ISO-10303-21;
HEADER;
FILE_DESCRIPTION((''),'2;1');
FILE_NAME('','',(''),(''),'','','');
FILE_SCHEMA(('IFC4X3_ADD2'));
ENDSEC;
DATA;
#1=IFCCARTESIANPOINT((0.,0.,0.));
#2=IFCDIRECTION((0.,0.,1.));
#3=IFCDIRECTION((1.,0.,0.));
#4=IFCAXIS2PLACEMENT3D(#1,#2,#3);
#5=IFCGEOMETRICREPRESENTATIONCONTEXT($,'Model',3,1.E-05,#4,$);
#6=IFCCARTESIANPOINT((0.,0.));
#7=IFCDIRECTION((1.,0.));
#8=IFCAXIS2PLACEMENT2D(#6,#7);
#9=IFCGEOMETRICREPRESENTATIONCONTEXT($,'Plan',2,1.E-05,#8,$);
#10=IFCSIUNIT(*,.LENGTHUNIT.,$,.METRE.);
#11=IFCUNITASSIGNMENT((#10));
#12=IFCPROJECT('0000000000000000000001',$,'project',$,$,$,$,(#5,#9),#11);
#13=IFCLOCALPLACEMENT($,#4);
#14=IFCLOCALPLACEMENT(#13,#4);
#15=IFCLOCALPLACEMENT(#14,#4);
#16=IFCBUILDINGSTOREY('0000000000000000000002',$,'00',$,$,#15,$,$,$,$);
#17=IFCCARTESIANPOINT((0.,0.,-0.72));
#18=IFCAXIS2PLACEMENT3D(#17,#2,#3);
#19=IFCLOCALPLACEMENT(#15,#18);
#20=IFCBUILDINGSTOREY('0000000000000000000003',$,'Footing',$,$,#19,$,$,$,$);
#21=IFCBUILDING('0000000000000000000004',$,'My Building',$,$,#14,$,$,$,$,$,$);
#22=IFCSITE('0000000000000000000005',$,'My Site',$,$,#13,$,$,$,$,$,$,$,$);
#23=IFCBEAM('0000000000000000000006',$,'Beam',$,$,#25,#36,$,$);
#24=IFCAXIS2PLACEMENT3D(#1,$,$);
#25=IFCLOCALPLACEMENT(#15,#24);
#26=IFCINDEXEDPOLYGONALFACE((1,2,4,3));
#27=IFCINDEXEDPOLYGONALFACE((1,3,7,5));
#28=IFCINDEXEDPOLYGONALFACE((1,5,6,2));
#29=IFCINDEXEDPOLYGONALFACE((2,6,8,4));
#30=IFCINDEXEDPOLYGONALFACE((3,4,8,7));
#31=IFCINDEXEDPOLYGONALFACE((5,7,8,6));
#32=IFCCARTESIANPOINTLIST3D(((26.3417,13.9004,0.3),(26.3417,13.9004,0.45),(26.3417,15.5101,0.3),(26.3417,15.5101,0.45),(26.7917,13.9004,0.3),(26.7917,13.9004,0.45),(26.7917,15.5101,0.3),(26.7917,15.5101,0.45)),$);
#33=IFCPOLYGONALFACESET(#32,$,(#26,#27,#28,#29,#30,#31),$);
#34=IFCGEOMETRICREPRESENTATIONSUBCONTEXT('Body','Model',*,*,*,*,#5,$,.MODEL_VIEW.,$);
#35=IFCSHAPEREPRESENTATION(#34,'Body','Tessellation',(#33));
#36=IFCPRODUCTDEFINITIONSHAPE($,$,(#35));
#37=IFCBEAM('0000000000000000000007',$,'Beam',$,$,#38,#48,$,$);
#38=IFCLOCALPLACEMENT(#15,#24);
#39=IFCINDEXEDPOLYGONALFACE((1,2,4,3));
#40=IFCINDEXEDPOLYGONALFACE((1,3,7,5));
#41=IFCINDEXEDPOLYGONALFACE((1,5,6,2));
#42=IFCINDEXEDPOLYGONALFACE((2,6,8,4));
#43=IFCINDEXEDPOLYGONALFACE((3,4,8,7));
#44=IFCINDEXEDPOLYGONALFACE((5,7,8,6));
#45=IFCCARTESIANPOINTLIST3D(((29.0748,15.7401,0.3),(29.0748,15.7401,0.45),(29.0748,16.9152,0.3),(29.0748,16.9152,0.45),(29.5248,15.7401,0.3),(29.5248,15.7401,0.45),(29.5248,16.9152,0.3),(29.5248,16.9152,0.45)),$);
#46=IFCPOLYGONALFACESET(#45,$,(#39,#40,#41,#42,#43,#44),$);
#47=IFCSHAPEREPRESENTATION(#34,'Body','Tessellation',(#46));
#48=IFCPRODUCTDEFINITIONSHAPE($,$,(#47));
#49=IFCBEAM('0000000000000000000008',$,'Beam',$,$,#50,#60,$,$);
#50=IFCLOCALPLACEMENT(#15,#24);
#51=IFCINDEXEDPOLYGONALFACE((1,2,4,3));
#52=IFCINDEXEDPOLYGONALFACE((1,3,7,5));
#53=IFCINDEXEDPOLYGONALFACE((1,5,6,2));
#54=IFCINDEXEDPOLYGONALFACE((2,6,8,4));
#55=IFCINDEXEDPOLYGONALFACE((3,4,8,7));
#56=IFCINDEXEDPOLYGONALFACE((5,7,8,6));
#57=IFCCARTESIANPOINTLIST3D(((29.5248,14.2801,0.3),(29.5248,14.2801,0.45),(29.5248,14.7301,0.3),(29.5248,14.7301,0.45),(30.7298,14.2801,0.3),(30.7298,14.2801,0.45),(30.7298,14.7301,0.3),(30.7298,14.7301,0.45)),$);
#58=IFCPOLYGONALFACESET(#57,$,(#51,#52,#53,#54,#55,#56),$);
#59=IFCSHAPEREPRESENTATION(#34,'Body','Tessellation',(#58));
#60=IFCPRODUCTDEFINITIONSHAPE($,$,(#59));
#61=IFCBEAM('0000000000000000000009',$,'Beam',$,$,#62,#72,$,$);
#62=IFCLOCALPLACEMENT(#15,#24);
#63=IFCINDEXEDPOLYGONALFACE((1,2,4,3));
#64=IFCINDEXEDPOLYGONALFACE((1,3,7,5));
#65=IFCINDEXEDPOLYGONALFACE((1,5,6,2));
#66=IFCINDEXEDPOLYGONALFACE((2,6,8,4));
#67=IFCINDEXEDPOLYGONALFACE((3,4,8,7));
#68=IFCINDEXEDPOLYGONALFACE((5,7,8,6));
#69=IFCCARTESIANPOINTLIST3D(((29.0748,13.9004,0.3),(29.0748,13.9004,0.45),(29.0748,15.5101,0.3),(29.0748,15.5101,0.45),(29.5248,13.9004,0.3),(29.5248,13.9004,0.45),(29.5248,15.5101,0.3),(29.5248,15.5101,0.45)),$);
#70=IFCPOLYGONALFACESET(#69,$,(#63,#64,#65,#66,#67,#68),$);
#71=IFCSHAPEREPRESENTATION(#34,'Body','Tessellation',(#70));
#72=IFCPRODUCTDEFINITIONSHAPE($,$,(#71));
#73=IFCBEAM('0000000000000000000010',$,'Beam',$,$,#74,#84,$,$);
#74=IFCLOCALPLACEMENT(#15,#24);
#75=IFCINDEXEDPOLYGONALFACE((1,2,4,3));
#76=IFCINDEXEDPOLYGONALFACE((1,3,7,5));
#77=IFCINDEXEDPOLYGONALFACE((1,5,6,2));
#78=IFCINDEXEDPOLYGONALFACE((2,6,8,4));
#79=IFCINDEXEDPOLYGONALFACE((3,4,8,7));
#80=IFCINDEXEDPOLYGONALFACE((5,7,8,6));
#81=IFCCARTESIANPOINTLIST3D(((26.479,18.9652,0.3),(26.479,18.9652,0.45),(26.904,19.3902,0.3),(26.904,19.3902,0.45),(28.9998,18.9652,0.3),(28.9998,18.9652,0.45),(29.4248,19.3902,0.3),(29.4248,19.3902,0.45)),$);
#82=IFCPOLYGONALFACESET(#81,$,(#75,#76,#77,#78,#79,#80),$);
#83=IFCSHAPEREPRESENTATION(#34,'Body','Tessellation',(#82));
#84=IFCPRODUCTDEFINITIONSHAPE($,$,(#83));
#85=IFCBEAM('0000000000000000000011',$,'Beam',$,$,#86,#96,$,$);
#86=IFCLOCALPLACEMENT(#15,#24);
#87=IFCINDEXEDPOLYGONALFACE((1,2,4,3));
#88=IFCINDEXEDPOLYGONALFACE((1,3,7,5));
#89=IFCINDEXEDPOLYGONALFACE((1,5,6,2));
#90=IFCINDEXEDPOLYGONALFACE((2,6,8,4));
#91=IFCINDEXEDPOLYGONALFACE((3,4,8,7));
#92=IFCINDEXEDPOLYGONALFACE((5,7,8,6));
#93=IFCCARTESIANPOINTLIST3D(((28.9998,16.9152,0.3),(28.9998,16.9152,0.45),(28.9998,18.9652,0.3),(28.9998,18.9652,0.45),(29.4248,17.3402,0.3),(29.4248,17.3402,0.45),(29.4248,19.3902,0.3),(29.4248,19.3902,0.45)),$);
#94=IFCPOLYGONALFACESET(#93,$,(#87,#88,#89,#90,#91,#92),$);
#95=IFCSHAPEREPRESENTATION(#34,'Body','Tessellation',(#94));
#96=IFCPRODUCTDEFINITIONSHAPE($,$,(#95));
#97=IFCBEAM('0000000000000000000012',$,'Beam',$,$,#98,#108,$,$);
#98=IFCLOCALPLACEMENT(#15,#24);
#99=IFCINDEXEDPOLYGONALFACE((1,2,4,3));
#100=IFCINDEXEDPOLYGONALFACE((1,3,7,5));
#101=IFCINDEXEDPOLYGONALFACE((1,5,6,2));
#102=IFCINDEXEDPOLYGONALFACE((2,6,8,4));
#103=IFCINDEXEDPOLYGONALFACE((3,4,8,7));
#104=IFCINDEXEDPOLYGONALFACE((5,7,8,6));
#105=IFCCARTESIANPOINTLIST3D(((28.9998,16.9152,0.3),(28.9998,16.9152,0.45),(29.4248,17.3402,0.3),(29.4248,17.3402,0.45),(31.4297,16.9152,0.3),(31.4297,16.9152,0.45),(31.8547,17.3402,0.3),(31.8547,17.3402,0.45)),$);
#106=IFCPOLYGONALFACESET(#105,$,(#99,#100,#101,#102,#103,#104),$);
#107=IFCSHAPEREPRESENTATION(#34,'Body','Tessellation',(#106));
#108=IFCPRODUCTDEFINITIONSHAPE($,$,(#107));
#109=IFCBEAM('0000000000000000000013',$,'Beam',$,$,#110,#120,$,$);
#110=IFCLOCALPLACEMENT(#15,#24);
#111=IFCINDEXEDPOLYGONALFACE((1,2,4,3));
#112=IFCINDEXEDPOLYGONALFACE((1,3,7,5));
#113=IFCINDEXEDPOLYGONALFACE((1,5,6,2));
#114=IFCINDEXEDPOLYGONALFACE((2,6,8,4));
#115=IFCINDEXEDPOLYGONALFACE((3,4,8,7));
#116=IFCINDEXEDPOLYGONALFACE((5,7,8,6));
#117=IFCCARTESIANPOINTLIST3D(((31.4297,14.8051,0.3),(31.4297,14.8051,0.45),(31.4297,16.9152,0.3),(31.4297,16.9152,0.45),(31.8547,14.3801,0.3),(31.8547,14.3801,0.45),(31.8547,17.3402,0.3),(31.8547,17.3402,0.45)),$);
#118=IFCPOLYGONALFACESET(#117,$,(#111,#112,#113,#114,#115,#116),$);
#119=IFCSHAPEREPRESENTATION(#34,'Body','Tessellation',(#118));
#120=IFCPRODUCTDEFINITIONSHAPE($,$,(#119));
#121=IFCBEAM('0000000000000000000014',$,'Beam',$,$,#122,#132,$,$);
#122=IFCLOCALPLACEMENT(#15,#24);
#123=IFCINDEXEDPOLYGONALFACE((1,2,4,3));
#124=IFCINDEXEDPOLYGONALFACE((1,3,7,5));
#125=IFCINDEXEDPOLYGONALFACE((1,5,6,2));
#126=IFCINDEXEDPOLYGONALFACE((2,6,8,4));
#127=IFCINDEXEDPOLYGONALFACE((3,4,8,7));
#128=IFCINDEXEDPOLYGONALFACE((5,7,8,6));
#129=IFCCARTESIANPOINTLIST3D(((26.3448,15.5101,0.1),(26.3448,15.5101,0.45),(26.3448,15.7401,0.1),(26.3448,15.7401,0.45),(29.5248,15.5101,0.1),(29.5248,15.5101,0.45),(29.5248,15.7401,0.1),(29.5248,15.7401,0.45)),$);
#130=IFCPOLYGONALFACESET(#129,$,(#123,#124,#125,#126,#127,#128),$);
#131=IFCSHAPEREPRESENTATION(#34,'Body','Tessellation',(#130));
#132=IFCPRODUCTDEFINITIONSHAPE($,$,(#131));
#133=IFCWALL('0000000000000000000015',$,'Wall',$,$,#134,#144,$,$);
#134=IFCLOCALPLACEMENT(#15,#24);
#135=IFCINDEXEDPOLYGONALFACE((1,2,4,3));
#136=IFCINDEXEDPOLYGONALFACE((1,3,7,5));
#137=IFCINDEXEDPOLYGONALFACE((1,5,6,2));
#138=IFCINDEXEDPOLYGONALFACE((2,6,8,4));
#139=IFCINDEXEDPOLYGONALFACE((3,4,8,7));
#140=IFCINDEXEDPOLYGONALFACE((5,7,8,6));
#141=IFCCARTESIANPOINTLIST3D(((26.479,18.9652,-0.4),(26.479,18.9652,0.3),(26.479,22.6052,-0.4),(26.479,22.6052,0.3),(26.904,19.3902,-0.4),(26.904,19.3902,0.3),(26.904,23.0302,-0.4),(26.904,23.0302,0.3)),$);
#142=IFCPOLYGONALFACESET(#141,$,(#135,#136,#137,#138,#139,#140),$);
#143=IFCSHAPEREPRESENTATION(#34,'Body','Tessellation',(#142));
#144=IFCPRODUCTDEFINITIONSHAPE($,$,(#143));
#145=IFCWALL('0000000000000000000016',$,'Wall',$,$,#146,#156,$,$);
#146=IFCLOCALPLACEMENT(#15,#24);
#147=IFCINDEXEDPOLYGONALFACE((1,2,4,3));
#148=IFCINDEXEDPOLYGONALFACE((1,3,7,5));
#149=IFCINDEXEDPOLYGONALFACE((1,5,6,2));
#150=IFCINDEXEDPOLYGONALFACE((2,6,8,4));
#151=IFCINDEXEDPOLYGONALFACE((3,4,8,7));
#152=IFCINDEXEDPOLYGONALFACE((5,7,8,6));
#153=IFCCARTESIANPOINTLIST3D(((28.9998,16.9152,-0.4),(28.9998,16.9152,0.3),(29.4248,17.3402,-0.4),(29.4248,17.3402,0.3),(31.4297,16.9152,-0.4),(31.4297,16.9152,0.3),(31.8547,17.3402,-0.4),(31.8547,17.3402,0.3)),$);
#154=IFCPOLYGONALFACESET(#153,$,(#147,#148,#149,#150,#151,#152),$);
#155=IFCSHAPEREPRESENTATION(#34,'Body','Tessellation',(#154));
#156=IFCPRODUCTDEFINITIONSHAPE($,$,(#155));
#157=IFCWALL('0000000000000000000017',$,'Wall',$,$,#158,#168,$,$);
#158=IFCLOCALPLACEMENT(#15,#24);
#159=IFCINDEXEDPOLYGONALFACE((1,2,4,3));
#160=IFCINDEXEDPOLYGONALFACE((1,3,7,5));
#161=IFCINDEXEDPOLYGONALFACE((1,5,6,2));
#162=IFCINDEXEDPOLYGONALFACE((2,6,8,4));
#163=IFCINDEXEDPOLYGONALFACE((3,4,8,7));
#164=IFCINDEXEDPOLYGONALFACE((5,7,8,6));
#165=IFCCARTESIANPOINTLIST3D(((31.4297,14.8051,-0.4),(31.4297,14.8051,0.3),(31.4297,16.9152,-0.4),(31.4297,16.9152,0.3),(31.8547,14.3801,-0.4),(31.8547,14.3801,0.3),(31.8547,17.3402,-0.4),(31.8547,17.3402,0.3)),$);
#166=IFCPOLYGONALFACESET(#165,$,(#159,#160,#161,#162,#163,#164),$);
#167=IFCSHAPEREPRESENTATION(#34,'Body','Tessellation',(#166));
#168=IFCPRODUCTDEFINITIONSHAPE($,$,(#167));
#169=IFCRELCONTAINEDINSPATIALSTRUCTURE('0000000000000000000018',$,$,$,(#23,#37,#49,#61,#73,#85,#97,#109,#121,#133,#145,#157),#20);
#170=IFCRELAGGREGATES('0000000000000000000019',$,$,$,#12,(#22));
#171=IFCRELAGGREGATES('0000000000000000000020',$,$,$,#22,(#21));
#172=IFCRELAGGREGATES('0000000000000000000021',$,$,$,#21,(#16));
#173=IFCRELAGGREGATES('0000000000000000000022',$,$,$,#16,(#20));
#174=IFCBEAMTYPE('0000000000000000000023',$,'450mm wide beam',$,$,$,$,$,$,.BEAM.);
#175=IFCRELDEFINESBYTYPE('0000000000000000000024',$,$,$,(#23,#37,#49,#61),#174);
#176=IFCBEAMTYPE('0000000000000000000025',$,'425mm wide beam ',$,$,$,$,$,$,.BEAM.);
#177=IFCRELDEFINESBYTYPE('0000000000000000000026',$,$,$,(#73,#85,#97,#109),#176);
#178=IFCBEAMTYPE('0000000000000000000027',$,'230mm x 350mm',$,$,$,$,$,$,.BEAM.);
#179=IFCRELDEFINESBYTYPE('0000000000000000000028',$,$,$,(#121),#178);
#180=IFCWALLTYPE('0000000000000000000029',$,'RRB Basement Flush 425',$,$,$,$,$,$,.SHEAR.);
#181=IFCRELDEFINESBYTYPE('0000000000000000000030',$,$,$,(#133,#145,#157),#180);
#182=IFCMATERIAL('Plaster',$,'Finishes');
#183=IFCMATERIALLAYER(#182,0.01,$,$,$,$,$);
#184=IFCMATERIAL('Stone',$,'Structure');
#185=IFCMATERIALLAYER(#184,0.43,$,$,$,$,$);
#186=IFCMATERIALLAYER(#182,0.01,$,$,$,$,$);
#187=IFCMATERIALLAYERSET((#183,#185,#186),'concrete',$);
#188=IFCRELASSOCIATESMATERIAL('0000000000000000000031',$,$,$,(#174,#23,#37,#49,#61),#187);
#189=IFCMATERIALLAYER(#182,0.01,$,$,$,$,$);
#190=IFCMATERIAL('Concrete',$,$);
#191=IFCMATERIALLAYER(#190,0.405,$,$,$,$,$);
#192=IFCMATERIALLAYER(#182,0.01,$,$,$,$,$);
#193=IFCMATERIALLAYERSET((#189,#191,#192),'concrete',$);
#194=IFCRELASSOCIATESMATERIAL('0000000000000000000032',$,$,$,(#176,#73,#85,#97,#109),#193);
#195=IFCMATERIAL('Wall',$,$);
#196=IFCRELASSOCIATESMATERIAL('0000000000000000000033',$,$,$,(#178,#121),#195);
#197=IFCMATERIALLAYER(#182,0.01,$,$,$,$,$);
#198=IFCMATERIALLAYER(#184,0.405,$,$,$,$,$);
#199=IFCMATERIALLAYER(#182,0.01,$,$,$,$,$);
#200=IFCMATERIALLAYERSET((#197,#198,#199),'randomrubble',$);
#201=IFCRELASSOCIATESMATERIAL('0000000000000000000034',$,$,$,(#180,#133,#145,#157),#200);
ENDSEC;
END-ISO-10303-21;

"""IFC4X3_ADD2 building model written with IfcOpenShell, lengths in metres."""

from ifc_helpers import new_model, si_unit, frame, origin_with_axes, origin_2d_with_axis, place, context, subcontext, project, spatial, line, indexed_curve, rectangle, outline, extrude, material, layer, layer_set, layer_usage, material_profile, profile_set, profile_usage, type_object, element, save


model = new_model("IFC4X3_ADD2")

# Units and contexts
model_context = context("Model", 3, precision=1e-05, world=origin_with_axes())
plan_context = context("Plan", 2, precision=1e-05, world=origin_2d_with_axis())
body_context = subcontext(model_context, "Body", "Model", "MODEL_VIEW")
ifc_project = project(units=[si_unit("LENGTHUNIT", "METRE")], contexts=[model_context, plan_context])

# Site, building, storeys
site_placement = place(None, origin_with_axes())
site = spatial("IfcSite", under=ifc_project, at=site_placement, Name="My Site")
building_placement = place(site_placement, origin_with_axes())
building = spatial("IfcBuilding", under=site, at=building_placement, Name="My Building")
storey_1_placement = place(building_placement, origin_with_axes())
storey_1 = spatial("IfcBuildingStorey", under=building, at=storey_1_placement, Name="00")
storey_2_placement = place(storey_1_placement, frame((0.0, 0.0, -0.72), z_axis=(0.0, 0.0, 1.0), x_axis=(1.0, 0.0, 0.0)))
storey_2 = spatial("IfcBuildingStorey", under=storey_1, at=storey_2_placement, Name="Footing")

# Beams
ifc_material_1 = material(Name="Plaster", Category="Finishes")
ifc_layer_1 = layer(ifc_material_1, 0.01)
ifc_material_2 = material(Name="Stone", Category="Structure")
ifc_layer_2 = layer(ifc_material_2, 0.43)
ifc_layer_3 = layer(ifc_material_1, 0.01)
ifc_layer_set_1 = layer_set([ifc_layer_1, ifc_layer_2, ifc_layer_3], Name="concrete")
ifc_layer_usage_1 = layer_usage(ifc_layer_set_1, "AXIS2", "NEGATIVE", 0.0)
beam_type_1 = type_object("IfcBeamType", Name="450mm wide beam", PredefinedType="BEAM", material=ifc_layer_set_1)
beam_1_placement = place(storey_2_placement, frame((26.7917, 15.5101, 1.02), z_axis=(0.0, 0.0, 1.0), x_axis=(0.0, -1.0, 0.0)))
element("IfcBeam", 1, at=beam_1_placement, inside=storey_2, type_object=beam_type_1, material=ifc_layer_usage_1, Name="Beam", context=body_context, shape_type="SweptSolid", body=[
    extrude(outline(indexed_curve([(0.0, -0.45), (0.0, 0.0), (1.6097, 0.0), (1.6097, -0.45)], segments=[line(1, 2, 3, 4, 1)])), origin_with_axes(), (0.0, 0.0, 1.0), 0.15),
])
ifc_layer_usage_2 = layer_usage(ifc_layer_set_1, "AXIS2", "NEGATIVE", 0.0)
beam_2_placement = place(storey_2_placement, frame((29.5248, 16.9152, 1.02), z_axis=(0.0, 0.0, 1.0), x_axis=(0.0, -1.0, 0.0)))
element("IfcBeam", 2, at=beam_2_placement, inside=storey_2, type_object=beam_type_1, material=ifc_layer_usage_2, Name="Beam", context=body_context, shape_type="SweptSolid", body=[
    extrude(outline(indexed_curve([(0.0, -0.45), (0.0, 0.0), (1.175, 0.0), (1.175, -0.45)], segments=[line(1, 2, 3, 4, 1)])), origin_with_axes(), (0.0, 0.0, 1.0), 0.15),
])
ifc_layer_usage_3 = layer_usage(ifc_layer_set_1, "AXIS2", "NEGATIVE", 0.0)
beam_3_placement = place(storey_2_placement, frame((29.5248, 14.7301, 1.02), z_axis=(0.0, 0.0, 1.0), x_axis=(1.0, 0.0, 0.0)))
element("IfcBeam", 3, at=beam_3_placement, inside=storey_2, type_object=beam_type_1, material=ifc_layer_usage_3, Name="Beam", context=body_context, shape_type="SweptSolid", body=[
    extrude(outline(indexed_curve([(0.0, -0.45), (0.0, 0.0), (1.205, 0.0), (1.205, -0.45)], segments=[line(1, 2, 3, 4, 1)])), origin_with_axes(), (0.0, 0.0, 1.0), 0.15),
])
ifc_layer_usage_4 = layer_usage(ifc_layer_set_1, "AXIS2", "NEGATIVE", 0.0)
beam_4_placement = place(storey_2_placement, frame((29.5248, 15.5101, 1.02), z_axis=(0.0, 0.0, 1.0), x_axis=(0.0, -1.0, 0.0)))
element("IfcBeam", 4, at=beam_4_placement, inside=storey_2, type_object=beam_type_1, material=ifc_layer_usage_4, Name="Beam", context=body_context, shape_type="SweptSolid", body=[
    extrude(outline(indexed_curve([(0.0, -0.45), (0.0, 0.0), (1.6097, 0.0), (1.6097, -0.45)], segments=[line(1, 2, 3, 4, 1)])), origin_with_axes(), (0.0, 0.0, 1.0), 0.15),
])
ifc_layer_4 = layer(ifc_material_1, 0.01)
ifc_material_3 = material(Name="Concrete")
ifc_layer_5 = layer(ifc_material_3, 0.405)
ifc_layer_6 = layer(ifc_material_1, 0.01)
ifc_layer_set_2 = layer_set([ifc_layer_4, ifc_layer_5, ifc_layer_6], Name="concrete")
ifc_layer_usage_5 = layer_usage(ifc_layer_set_2, "AXIS2", "POSITIVE", 0.0)
beam_type_2 = type_object("IfcBeamType", Name="425mm wide beam ", PredefinedType="BEAM", material=ifc_layer_set_2)
beam_5_placement = place(storey_2_placement, frame((26.479, 18.9652, 1.02), z_axis=(0.0, 0.0, 1.0), x_axis=(1.0, 0.0, 0.0)))
element("IfcBeam", 5, at=beam_5_placement, inside=storey_2, type_object=beam_type_2, material=ifc_layer_usage_5, Name="Beam", context=body_context, shape_type="SweptSolid", body=[
    extrude(outline(indexed_curve([(0.0, 0.0), (0.425, 0.425), (2.9458, 0.425), (2.5208, 0.0)], segments=[line(1, 2, 3, 4, 1)])), origin_with_axes(), (0.0, 0.0, 1.0), 0.15),
])
ifc_layer_usage_6 = layer_usage(ifc_layer_set_2, "AXIS2", "POSITIVE", 0.0)
beam_6_placement = place(storey_2_placement, frame((28.9998, 18.9652, 1.02), z_axis=(0.0, 0.0, 1.0), x_axis=(0.0, -1.0, 0.0)))
element("IfcBeam", 6, at=beam_6_placement, inside=storey_2, type_object=beam_type_2, material=ifc_layer_usage_6, Name="Beam", context=body_context, shape_type="SweptSolid", body=[
    extrude(outline(indexed_curve([(0.0, 0.0), (-0.425, 0.425), (1.625, 0.425), (2.05, 0.0)], segments=[line(1, 2, 3, 4, 1)])), origin_with_axes(), (0.0, 0.0, 1.0), 0.15),
])
ifc_layer_usage_7 = layer_usage(ifc_layer_set_2, "AXIS2", "POSITIVE", 0.0)
beam_7_placement = place(storey_2_placement, frame((28.9998, 16.9152, 1.02), z_axis=(0.0, 0.0, 1.0), x_axis=(1.0, 0.0, 0.0)))
element("IfcBeam", 7, at=beam_7_placement, inside=storey_2, type_object=beam_type_2, material=ifc_layer_usage_7, Name="Beam", context=body_context, shape_type="SweptSolid", body=[
    extrude(outline(indexed_curve([(0.0, 0.0), (0.425, 0.425), (2.855, 0.425), (2.43, 0.0)], segments=[line(1, 2, 3, 4, 1)])), origin_with_axes(), (0.0, 0.0, 1.0), 0.15),
])
ifc_layer_usage_8 = layer_usage(ifc_layer_set_2, "AXIS2", "POSITIVE", 0.0)
beam_8_placement = place(storey_2_placement, frame((31.4297, 16.9152, 1.02), z_axis=(0.0, 0.0, 1.0), x_axis=(0.0, -1.0, 0.0)))
element("IfcBeam", 8, at=beam_8_placement, inside=storey_2, type_object=beam_type_2, material=ifc_layer_usage_8, Name="Beam", context=body_context, shape_type="SweptSolid", body=[
    extrude(outline(indexed_curve([(0.0, 0.0), (-0.425, 0.425), (2.535, 0.425), (2.11, 0.0)], segments=[line(1, 2, 3, 4, 1)])), origin_with_axes(), (0.0, 0.0, 1.0), 0.15),
])
ifc_material_4 = material(Name="Wall")
ifc_material_profile_1 = material_profile(ifc_material_4, rectangle(XDim=0.23, YDim=0.35))
ifc_profile_set_1 = profile_set([ifc_material_profile_1], Name="concrete")
ifc_profile_usage_1 = profile_usage(ifc_profile_set_1)
beam_type_3 = type_object("IfcBeamType", Name="230mm x 350mm", PredefinedType="BEAM", material=ifc_profile_set_1)
beam_9_placement = place(storey_2_placement, frame((29.5248, 15.6251, 0.995), z_axis=(-1.0, -0.000001, 0.000001), x_axis=(0.000001, -1.0, 0.0)))
element("IfcBeam", 9, at=beam_9_placement, inside=storey_2, type_object=beam_type_3, material=ifc_profile_usage_1, Name="Beam", context=body_context, shape_type="SweptSolid", body=[
    extrude(rectangle(XDim=0.23, YDim=0.35), origin_with_axes(), (0.0, 0.0, 1.0), 3.18),
])

# Walls
ifc_layer_7 = layer(ifc_material_1, 0.01)
ifc_layer_8 = layer(ifc_material_2, 0.405)
ifc_layer_9 = layer(ifc_material_1, 0.01)
ifc_layer_set_3 = layer_set([ifc_layer_7, ifc_layer_8, ifc_layer_9], Name="randomrubble")
ifc_layer_usage_9 = layer_usage(ifc_layer_set_3, "AXIS2", "POSITIVE", 0.0)
wall_type_1 = type_object("IfcWallType", Name="RRB Basement Flush 425", PredefinedType="SHEAR", material=ifc_layer_set_3)
wall_1_placement = place(storey_2_placement, frame((26.904, 18.9652, 0.32), z_axis=(0.0, 0.0, 1.0), x_axis=(0.0, 1.0, 0.0)))
element("IfcWall", 10, at=wall_1_placement, inside=storey_2, type_object=wall_type_1, material=ifc_layer_usage_9, Name="Wall", context=body_context, shape_type="SweptSolid", body=[
    extrude(outline(indexed_curve([(0.425, 0.0), (0.0, 0.425), (3.64, 0.425), (4.065, 0.0)], segments=[line(1, 2, 3, 4, 1)])), origin_with_axes(), (0.0, 0.0, 1.0), 0.7),
])
ifc_layer_usage_10 = layer_usage(ifc_layer_set_3, "AXIS2", "POSITIVE", 0.0)
wall_2_placement = place(storey_2_placement, frame((29.4248, 16.9152, 0.32), z_axis=(0.0, 0.0, 1.0), x_axis=(1.0, 0.0, 0.0)))
element("IfcWall", 11, at=wall_2_placement, inside=storey_2, type_object=wall_type_1, material=ifc_layer_usage_10, Name="Wall", context=body_context, shape_type="SweptSolid", body=[
    extrude(outline(indexed_curve([(-0.425, 0.0), (0.0, 0.425), (2.43, 0.425), (2.005, 0.0)], segments=[line(1, 2, 3, 4, 1)])), origin_with_axes(), (0.0, 0.0, 1.0), 0.7),
])
ifc_layer_usage_11 = layer_usage(ifc_layer_set_3, "AXIS2", "POSITIVE", 0.0)
wall_3_placement = place(storey_2_placement, frame((31.8547, 14.3801, 0.32), z_axis=(0.0, 0.0, 1.0), x_axis=(0.0, 1.0, 0.0)))
element("IfcWall", 12, at=wall_3_placement, inside=storey_2, type_object=wall_type_1, material=ifc_layer_usage_11, Name="Wall", context=body_context, shape_type="SweptSolid", body=[
    extrude(outline(indexed_curve([(0.0, 0.0), (0.425, 0.425), (2.535, 0.425), (2.96, 0.0)], segments=[line(1, 2, 3, 4, 1)])), origin_with_axes(), (0.0, 0.0, 1.0), 0.7),
])

save(model, "model.ifc")
